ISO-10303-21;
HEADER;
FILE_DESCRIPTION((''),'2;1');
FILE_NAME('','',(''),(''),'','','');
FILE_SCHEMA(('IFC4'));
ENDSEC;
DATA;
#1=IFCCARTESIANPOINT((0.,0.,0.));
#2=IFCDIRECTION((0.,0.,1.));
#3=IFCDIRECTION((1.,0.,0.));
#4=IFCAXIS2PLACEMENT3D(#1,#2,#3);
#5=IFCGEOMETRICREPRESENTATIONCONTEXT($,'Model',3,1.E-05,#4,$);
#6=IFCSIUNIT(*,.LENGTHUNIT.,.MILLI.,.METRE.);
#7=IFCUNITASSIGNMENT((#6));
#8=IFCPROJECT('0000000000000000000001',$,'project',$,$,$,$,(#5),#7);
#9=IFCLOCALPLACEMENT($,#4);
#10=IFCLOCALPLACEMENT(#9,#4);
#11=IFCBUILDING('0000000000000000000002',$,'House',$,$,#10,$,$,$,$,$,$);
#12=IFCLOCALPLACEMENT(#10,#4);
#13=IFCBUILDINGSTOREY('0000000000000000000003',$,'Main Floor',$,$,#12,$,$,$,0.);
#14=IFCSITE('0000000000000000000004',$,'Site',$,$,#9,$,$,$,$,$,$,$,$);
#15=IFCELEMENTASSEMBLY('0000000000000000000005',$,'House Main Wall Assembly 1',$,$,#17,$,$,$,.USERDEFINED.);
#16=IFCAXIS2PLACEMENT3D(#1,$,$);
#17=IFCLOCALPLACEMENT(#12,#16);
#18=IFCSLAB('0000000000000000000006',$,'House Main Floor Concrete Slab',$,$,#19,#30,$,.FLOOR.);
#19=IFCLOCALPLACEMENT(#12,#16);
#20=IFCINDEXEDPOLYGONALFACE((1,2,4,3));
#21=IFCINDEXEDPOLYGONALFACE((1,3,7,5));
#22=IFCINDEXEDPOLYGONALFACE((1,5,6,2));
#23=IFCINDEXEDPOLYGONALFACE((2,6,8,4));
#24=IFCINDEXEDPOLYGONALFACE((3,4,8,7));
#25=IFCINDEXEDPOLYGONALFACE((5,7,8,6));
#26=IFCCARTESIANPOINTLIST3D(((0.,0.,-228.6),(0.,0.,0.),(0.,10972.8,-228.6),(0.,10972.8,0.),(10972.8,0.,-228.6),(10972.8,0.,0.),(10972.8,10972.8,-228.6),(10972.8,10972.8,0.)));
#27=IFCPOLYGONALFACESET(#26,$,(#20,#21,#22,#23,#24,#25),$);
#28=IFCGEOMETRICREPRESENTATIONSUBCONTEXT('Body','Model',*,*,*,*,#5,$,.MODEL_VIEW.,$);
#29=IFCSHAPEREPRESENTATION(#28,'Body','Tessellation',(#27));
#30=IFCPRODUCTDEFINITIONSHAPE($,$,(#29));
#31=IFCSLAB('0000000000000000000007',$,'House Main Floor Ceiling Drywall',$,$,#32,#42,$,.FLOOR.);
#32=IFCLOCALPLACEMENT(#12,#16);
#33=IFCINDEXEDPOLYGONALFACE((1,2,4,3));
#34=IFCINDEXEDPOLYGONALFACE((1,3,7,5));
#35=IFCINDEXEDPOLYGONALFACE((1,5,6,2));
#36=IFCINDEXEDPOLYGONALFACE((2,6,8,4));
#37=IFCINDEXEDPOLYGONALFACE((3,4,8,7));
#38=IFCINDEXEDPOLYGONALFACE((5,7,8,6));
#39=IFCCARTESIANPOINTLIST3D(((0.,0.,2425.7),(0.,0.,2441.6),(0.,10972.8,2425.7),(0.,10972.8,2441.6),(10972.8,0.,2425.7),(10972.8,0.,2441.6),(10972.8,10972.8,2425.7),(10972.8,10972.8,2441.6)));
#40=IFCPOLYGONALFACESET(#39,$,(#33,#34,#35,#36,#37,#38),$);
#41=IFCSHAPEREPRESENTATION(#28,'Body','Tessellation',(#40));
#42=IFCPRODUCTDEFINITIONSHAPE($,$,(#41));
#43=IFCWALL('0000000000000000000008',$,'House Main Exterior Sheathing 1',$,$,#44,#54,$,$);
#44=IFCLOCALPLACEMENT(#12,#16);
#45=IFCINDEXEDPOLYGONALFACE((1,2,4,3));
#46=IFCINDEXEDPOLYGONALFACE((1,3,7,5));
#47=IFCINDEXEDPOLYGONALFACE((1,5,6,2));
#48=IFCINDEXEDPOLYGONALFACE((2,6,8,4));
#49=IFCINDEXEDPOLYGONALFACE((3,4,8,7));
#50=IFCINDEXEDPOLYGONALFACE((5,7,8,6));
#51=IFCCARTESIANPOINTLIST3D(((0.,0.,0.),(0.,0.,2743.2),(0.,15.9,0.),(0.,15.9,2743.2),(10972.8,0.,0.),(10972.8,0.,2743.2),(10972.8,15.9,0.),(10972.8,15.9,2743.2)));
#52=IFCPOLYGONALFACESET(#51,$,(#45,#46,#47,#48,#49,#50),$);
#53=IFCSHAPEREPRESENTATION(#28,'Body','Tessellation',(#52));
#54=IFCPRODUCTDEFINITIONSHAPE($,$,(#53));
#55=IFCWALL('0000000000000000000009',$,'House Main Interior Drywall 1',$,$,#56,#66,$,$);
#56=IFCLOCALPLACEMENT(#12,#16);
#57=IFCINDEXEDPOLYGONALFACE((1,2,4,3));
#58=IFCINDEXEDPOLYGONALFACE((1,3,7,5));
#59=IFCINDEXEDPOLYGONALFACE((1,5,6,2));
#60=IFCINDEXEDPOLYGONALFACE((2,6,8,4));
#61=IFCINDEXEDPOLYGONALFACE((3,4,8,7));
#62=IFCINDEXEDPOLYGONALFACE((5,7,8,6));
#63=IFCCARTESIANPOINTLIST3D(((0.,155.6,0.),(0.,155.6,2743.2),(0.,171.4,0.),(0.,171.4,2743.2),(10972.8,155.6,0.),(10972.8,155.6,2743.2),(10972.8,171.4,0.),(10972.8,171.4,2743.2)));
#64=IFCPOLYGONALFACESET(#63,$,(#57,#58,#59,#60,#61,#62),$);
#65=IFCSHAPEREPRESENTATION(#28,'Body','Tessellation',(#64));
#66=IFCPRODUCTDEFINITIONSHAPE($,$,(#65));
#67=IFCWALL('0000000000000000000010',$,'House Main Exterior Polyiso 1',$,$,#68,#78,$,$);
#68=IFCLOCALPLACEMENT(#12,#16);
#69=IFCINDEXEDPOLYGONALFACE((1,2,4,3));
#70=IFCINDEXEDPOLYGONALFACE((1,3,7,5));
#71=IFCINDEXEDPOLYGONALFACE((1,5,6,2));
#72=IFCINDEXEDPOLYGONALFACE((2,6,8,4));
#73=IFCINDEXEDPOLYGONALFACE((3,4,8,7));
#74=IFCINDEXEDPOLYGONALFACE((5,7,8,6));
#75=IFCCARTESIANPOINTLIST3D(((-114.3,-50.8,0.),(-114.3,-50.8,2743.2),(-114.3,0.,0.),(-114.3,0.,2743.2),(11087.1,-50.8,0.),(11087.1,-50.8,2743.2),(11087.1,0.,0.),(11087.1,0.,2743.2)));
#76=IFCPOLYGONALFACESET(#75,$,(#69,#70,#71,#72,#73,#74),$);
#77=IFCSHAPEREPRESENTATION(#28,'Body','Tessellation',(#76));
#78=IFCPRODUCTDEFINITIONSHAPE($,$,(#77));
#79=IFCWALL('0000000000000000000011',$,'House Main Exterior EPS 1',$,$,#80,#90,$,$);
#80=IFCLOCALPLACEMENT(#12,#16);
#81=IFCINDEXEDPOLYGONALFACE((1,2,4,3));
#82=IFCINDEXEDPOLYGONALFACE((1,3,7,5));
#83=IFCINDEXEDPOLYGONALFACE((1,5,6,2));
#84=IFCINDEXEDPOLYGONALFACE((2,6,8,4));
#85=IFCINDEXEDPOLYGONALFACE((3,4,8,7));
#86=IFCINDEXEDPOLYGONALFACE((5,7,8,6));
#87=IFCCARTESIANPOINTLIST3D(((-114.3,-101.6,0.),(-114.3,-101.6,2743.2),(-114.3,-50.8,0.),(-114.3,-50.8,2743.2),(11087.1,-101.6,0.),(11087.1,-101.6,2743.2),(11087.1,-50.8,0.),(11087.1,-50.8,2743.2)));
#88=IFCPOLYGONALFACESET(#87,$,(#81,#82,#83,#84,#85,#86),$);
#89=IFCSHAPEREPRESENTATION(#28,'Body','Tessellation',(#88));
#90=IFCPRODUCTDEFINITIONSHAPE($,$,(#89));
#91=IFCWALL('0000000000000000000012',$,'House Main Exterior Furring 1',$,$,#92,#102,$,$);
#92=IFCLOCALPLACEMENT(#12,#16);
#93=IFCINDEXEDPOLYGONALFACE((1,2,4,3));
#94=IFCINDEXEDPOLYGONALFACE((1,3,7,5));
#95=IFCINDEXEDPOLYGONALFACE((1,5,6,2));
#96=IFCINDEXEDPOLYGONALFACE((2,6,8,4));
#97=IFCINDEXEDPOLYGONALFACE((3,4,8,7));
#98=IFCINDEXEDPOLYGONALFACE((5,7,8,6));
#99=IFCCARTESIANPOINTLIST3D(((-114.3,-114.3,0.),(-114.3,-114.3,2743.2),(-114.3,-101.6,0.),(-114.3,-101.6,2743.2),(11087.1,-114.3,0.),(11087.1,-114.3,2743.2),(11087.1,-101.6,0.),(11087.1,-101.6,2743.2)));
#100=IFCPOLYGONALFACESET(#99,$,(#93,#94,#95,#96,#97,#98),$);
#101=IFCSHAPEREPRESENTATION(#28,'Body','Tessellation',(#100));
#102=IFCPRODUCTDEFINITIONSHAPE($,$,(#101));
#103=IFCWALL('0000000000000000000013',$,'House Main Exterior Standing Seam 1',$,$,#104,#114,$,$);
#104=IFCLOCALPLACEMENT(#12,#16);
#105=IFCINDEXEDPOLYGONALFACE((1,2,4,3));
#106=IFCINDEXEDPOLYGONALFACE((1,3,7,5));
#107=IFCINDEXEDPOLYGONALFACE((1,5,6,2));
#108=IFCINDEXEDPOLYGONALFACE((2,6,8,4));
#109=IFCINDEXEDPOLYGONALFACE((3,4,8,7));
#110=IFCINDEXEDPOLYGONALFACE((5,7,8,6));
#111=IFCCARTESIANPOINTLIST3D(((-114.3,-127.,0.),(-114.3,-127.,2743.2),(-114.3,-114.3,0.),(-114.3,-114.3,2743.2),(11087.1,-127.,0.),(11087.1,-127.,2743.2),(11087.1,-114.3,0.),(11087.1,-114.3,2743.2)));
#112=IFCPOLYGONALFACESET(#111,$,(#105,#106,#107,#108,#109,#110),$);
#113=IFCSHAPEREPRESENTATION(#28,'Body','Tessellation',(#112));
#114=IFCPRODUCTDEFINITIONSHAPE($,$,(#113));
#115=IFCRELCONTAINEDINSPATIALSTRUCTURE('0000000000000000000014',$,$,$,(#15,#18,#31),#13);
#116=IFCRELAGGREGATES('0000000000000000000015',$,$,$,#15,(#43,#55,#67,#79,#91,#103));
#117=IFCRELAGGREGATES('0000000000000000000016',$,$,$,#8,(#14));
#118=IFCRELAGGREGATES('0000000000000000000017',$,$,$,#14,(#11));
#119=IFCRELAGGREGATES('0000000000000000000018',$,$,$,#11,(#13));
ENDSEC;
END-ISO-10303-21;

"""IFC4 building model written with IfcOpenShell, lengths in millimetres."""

from ifc_helpers import new_model, si_unit, frame, origin_with_axes, place, context, subcontext, project, spatial, indexed_curve, outline, extrude, element, aggregate, save


model = new_model("IFC4")

# Units and contexts
model_context = context("Model", 3, precision=1e-05, world=origin_with_axes())
body_context = subcontext(model_context, "Body", "Model", "MODEL_VIEW")
ifc_project = project(units=[si_unit("LENGTHUNIT", "METRE", prefix="MILLI")], contexts=[model_context])

# Site, building, storey
site_placement = place(None, origin_with_axes())
site = spatial("IfcSite", under=ifc_project, at=site_placement, Name="Site")
building_placement = place(site_placement, origin_with_axes())
building = spatial("IfcBuilding", under=site, at=building_placement, Name="House")
storey_placement = place(building_placement, origin_with_axes())
storey = spatial("IfcBuildingStorey", under=building, at=storey_placement, Name="Main Floor", Elevation=0.0)

# Element assembly
assembly_1_placement = place(storey_placement, origin_with_axes())
assembly_1 = element("IfcElementAssembly", 1, at=assembly_1_placement, inside=storey, Name="House Main Wall Assembly 1", PredefinedType="USERDEFINED")

# Slabs
slab_1_placement = place(storey_placement, frame((0.0, 0.0, -228.6), z_axis=(0.0, 0.0, 1.0), x_axis=(1.0, 0.0, 0.0)))
element("IfcSlab", 2, at=slab_1_placement, inside=storey, Name="House Main Floor Concrete Slab", PredefinedType="FLOOR", context=body_context, shape_type="SweptSolid", body=[
    extrude(outline(indexed_curve([(0.0, 0.0), (10972.8, 0.0), (10972.8, 10972.8), (0.0, 10972.8), (0.0, 0.0)])), None, (0.0, 0.0, 1.0), 228.6),
])
slab_2_placement = place(storey_placement, frame((0.0, 0.0, 2425.7), z_axis=(0.0, 0.0, 1.0), x_axis=(1.0, 0.0, 0.0)))
element("IfcSlab", 3, at=slab_2_placement, inside=storey, Name="House Main Floor Ceiling Drywall", PredefinedType="FLOOR", context=body_context, shape_type="SweptSolid", body=[
    extrude(outline(indexed_curve([(0.0, 0.0), (10972.8, 0.0), (10972.8, 10972.8), (0.0, 10972.8), (0.0, 0.0)])), None, (0.0, 0.0, 1.0), 15.9),
])

# Walls
wall_1_placement = place(assembly_1_placement, origin_with_axes())
wall_1 = element("IfcWall", 4, at=wall_1_placement, Name="House Main Exterior Sheathing 1", context=body_context, shape_type="SweptSolid", body=[
    extrude(outline(indexed_curve([(0.0, 0.0), (0.0, 15.9), (10972.8, 15.9), (10972.8, 0.0), (0.0, 0.0)], self_intersect=False)), origin_with_axes(), (0.0, 0.0, 1.0), 2743.2),
])
wall_2_placement = place(assembly_1_placement, origin_with_axes())
wall_2 = element("IfcWall", 5, at=wall_2_placement, Name="House Main Interior Drywall 1", context=body_context, shape_type="SweptSolid", body=[
    extrude(outline(indexed_curve([(0.0, 0.0), (0.0, 15.9), (10972.8, 15.9), (10972.8, 0.0), (0.0, 0.0)], self_intersect=False)), frame((0.0, 155.6, 0.0), z_axis=(0.0, 0.0, 1.0), x_axis=(1.0, 0.0, 0.0)), (0.0, 0.0, 1.0), 2743.2),
])
wall_3_placement = place(assembly_1_placement, frame((-114.3, 0.0, 0.0), z_axis=(0.0, 0.0, 1.0), x_axis=(1.0, 0.0, 0.0)))
wall_3 = element("IfcWall", 6, at=wall_3_placement, Name="House Main Exterior Polyiso 1", context=body_context, shape_type="SweptSolid", body=[
    extrude(outline(indexed_curve([(0.0, 0.0), (0.0, -50.8), (11201.4, -50.8), (11201.4, 0.0), (0.0, 0.0)], self_intersect=False)), origin_with_axes(), (0.0, 0.0, 1.0), 2743.2),
])
wall_4_placement = place(assembly_1_placement, frame((-114.3, 0.0, 0.0), z_axis=(0.0, 0.0, 1.0), x_axis=(1.0, 0.0, 0.0)))
wall_4 = element("IfcWall", 7, at=wall_4_placement, Name="House Main Exterior EPS 1", context=body_context, shape_type="SweptSolid", body=[
    extrude(outline(indexed_curve([(0.0, 0.0), (0.0, -50.8), (11201.4, -50.8), (11201.4, 0.0), (0.0, 0.0)], self_intersect=False)), frame((0.0, -50.8, 0.0), z_axis=(0.0, 0.0, 1.0), x_axis=(1.0, 0.0, 0.0)), (0.0, 0.0, 1.0), 2743.2),
])
wall_5_placement = place(assembly_1_placement, frame((-114.3, 0.0, 0.0), z_axis=(0.0, 0.0, 1.0), x_axis=(1.0, 0.0, 0.0)))
wall_5 = element("IfcWall", 8, at=wall_5_placement, Name="House Main Exterior Furring 1", context=body_context, shape_type="SweptSolid", body=[
    extrude(outline(indexed_curve([(0.0, 0.0), (0.0, -12.7), (11201.4, -12.7), (11201.4, 0.0), (0.0, 0.0)], self_intersect=False)), frame((0.0, -101.6, 0.0), z_axis=(0.0, 0.0, 1.0), x_axis=(1.0, 0.0, 0.0)), (0.0, 0.0, 1.0), 2743.2),
])
wall_6_placement = place(assembly_1_placement, frame((-114.3, 0.0, 0.0), z_axis=(0.0, 0.0, 1.0), x_axis=(1.0, 0.0, 0.0)))
wall_6 = element("IfcWall", 9, at=wall_6_placement, Name="House Main Exterior Standing Seam 1", context=body_context, shape_type="SweptSolid", body=[
    extrude(outline(indexed_curve([(0.0, 0.0), (0.0, -12.7), (11201.4, -12.7), (11201.4, 0.0), (0.0, 0.0)], self_intersect=False)), frame((0.0, -114.3, 0.0), z_axis=(0.0, 0.0, 1.0), x_axis=(1.0, 0.0, 0.0)), (0.0, 0.0, 1.0), 2743.2),
])
aggregate(assembly_1, [wall_1, wall_2, wall_3, wall_4, wall_5, wall_6])

save(model, "model.ifc")
